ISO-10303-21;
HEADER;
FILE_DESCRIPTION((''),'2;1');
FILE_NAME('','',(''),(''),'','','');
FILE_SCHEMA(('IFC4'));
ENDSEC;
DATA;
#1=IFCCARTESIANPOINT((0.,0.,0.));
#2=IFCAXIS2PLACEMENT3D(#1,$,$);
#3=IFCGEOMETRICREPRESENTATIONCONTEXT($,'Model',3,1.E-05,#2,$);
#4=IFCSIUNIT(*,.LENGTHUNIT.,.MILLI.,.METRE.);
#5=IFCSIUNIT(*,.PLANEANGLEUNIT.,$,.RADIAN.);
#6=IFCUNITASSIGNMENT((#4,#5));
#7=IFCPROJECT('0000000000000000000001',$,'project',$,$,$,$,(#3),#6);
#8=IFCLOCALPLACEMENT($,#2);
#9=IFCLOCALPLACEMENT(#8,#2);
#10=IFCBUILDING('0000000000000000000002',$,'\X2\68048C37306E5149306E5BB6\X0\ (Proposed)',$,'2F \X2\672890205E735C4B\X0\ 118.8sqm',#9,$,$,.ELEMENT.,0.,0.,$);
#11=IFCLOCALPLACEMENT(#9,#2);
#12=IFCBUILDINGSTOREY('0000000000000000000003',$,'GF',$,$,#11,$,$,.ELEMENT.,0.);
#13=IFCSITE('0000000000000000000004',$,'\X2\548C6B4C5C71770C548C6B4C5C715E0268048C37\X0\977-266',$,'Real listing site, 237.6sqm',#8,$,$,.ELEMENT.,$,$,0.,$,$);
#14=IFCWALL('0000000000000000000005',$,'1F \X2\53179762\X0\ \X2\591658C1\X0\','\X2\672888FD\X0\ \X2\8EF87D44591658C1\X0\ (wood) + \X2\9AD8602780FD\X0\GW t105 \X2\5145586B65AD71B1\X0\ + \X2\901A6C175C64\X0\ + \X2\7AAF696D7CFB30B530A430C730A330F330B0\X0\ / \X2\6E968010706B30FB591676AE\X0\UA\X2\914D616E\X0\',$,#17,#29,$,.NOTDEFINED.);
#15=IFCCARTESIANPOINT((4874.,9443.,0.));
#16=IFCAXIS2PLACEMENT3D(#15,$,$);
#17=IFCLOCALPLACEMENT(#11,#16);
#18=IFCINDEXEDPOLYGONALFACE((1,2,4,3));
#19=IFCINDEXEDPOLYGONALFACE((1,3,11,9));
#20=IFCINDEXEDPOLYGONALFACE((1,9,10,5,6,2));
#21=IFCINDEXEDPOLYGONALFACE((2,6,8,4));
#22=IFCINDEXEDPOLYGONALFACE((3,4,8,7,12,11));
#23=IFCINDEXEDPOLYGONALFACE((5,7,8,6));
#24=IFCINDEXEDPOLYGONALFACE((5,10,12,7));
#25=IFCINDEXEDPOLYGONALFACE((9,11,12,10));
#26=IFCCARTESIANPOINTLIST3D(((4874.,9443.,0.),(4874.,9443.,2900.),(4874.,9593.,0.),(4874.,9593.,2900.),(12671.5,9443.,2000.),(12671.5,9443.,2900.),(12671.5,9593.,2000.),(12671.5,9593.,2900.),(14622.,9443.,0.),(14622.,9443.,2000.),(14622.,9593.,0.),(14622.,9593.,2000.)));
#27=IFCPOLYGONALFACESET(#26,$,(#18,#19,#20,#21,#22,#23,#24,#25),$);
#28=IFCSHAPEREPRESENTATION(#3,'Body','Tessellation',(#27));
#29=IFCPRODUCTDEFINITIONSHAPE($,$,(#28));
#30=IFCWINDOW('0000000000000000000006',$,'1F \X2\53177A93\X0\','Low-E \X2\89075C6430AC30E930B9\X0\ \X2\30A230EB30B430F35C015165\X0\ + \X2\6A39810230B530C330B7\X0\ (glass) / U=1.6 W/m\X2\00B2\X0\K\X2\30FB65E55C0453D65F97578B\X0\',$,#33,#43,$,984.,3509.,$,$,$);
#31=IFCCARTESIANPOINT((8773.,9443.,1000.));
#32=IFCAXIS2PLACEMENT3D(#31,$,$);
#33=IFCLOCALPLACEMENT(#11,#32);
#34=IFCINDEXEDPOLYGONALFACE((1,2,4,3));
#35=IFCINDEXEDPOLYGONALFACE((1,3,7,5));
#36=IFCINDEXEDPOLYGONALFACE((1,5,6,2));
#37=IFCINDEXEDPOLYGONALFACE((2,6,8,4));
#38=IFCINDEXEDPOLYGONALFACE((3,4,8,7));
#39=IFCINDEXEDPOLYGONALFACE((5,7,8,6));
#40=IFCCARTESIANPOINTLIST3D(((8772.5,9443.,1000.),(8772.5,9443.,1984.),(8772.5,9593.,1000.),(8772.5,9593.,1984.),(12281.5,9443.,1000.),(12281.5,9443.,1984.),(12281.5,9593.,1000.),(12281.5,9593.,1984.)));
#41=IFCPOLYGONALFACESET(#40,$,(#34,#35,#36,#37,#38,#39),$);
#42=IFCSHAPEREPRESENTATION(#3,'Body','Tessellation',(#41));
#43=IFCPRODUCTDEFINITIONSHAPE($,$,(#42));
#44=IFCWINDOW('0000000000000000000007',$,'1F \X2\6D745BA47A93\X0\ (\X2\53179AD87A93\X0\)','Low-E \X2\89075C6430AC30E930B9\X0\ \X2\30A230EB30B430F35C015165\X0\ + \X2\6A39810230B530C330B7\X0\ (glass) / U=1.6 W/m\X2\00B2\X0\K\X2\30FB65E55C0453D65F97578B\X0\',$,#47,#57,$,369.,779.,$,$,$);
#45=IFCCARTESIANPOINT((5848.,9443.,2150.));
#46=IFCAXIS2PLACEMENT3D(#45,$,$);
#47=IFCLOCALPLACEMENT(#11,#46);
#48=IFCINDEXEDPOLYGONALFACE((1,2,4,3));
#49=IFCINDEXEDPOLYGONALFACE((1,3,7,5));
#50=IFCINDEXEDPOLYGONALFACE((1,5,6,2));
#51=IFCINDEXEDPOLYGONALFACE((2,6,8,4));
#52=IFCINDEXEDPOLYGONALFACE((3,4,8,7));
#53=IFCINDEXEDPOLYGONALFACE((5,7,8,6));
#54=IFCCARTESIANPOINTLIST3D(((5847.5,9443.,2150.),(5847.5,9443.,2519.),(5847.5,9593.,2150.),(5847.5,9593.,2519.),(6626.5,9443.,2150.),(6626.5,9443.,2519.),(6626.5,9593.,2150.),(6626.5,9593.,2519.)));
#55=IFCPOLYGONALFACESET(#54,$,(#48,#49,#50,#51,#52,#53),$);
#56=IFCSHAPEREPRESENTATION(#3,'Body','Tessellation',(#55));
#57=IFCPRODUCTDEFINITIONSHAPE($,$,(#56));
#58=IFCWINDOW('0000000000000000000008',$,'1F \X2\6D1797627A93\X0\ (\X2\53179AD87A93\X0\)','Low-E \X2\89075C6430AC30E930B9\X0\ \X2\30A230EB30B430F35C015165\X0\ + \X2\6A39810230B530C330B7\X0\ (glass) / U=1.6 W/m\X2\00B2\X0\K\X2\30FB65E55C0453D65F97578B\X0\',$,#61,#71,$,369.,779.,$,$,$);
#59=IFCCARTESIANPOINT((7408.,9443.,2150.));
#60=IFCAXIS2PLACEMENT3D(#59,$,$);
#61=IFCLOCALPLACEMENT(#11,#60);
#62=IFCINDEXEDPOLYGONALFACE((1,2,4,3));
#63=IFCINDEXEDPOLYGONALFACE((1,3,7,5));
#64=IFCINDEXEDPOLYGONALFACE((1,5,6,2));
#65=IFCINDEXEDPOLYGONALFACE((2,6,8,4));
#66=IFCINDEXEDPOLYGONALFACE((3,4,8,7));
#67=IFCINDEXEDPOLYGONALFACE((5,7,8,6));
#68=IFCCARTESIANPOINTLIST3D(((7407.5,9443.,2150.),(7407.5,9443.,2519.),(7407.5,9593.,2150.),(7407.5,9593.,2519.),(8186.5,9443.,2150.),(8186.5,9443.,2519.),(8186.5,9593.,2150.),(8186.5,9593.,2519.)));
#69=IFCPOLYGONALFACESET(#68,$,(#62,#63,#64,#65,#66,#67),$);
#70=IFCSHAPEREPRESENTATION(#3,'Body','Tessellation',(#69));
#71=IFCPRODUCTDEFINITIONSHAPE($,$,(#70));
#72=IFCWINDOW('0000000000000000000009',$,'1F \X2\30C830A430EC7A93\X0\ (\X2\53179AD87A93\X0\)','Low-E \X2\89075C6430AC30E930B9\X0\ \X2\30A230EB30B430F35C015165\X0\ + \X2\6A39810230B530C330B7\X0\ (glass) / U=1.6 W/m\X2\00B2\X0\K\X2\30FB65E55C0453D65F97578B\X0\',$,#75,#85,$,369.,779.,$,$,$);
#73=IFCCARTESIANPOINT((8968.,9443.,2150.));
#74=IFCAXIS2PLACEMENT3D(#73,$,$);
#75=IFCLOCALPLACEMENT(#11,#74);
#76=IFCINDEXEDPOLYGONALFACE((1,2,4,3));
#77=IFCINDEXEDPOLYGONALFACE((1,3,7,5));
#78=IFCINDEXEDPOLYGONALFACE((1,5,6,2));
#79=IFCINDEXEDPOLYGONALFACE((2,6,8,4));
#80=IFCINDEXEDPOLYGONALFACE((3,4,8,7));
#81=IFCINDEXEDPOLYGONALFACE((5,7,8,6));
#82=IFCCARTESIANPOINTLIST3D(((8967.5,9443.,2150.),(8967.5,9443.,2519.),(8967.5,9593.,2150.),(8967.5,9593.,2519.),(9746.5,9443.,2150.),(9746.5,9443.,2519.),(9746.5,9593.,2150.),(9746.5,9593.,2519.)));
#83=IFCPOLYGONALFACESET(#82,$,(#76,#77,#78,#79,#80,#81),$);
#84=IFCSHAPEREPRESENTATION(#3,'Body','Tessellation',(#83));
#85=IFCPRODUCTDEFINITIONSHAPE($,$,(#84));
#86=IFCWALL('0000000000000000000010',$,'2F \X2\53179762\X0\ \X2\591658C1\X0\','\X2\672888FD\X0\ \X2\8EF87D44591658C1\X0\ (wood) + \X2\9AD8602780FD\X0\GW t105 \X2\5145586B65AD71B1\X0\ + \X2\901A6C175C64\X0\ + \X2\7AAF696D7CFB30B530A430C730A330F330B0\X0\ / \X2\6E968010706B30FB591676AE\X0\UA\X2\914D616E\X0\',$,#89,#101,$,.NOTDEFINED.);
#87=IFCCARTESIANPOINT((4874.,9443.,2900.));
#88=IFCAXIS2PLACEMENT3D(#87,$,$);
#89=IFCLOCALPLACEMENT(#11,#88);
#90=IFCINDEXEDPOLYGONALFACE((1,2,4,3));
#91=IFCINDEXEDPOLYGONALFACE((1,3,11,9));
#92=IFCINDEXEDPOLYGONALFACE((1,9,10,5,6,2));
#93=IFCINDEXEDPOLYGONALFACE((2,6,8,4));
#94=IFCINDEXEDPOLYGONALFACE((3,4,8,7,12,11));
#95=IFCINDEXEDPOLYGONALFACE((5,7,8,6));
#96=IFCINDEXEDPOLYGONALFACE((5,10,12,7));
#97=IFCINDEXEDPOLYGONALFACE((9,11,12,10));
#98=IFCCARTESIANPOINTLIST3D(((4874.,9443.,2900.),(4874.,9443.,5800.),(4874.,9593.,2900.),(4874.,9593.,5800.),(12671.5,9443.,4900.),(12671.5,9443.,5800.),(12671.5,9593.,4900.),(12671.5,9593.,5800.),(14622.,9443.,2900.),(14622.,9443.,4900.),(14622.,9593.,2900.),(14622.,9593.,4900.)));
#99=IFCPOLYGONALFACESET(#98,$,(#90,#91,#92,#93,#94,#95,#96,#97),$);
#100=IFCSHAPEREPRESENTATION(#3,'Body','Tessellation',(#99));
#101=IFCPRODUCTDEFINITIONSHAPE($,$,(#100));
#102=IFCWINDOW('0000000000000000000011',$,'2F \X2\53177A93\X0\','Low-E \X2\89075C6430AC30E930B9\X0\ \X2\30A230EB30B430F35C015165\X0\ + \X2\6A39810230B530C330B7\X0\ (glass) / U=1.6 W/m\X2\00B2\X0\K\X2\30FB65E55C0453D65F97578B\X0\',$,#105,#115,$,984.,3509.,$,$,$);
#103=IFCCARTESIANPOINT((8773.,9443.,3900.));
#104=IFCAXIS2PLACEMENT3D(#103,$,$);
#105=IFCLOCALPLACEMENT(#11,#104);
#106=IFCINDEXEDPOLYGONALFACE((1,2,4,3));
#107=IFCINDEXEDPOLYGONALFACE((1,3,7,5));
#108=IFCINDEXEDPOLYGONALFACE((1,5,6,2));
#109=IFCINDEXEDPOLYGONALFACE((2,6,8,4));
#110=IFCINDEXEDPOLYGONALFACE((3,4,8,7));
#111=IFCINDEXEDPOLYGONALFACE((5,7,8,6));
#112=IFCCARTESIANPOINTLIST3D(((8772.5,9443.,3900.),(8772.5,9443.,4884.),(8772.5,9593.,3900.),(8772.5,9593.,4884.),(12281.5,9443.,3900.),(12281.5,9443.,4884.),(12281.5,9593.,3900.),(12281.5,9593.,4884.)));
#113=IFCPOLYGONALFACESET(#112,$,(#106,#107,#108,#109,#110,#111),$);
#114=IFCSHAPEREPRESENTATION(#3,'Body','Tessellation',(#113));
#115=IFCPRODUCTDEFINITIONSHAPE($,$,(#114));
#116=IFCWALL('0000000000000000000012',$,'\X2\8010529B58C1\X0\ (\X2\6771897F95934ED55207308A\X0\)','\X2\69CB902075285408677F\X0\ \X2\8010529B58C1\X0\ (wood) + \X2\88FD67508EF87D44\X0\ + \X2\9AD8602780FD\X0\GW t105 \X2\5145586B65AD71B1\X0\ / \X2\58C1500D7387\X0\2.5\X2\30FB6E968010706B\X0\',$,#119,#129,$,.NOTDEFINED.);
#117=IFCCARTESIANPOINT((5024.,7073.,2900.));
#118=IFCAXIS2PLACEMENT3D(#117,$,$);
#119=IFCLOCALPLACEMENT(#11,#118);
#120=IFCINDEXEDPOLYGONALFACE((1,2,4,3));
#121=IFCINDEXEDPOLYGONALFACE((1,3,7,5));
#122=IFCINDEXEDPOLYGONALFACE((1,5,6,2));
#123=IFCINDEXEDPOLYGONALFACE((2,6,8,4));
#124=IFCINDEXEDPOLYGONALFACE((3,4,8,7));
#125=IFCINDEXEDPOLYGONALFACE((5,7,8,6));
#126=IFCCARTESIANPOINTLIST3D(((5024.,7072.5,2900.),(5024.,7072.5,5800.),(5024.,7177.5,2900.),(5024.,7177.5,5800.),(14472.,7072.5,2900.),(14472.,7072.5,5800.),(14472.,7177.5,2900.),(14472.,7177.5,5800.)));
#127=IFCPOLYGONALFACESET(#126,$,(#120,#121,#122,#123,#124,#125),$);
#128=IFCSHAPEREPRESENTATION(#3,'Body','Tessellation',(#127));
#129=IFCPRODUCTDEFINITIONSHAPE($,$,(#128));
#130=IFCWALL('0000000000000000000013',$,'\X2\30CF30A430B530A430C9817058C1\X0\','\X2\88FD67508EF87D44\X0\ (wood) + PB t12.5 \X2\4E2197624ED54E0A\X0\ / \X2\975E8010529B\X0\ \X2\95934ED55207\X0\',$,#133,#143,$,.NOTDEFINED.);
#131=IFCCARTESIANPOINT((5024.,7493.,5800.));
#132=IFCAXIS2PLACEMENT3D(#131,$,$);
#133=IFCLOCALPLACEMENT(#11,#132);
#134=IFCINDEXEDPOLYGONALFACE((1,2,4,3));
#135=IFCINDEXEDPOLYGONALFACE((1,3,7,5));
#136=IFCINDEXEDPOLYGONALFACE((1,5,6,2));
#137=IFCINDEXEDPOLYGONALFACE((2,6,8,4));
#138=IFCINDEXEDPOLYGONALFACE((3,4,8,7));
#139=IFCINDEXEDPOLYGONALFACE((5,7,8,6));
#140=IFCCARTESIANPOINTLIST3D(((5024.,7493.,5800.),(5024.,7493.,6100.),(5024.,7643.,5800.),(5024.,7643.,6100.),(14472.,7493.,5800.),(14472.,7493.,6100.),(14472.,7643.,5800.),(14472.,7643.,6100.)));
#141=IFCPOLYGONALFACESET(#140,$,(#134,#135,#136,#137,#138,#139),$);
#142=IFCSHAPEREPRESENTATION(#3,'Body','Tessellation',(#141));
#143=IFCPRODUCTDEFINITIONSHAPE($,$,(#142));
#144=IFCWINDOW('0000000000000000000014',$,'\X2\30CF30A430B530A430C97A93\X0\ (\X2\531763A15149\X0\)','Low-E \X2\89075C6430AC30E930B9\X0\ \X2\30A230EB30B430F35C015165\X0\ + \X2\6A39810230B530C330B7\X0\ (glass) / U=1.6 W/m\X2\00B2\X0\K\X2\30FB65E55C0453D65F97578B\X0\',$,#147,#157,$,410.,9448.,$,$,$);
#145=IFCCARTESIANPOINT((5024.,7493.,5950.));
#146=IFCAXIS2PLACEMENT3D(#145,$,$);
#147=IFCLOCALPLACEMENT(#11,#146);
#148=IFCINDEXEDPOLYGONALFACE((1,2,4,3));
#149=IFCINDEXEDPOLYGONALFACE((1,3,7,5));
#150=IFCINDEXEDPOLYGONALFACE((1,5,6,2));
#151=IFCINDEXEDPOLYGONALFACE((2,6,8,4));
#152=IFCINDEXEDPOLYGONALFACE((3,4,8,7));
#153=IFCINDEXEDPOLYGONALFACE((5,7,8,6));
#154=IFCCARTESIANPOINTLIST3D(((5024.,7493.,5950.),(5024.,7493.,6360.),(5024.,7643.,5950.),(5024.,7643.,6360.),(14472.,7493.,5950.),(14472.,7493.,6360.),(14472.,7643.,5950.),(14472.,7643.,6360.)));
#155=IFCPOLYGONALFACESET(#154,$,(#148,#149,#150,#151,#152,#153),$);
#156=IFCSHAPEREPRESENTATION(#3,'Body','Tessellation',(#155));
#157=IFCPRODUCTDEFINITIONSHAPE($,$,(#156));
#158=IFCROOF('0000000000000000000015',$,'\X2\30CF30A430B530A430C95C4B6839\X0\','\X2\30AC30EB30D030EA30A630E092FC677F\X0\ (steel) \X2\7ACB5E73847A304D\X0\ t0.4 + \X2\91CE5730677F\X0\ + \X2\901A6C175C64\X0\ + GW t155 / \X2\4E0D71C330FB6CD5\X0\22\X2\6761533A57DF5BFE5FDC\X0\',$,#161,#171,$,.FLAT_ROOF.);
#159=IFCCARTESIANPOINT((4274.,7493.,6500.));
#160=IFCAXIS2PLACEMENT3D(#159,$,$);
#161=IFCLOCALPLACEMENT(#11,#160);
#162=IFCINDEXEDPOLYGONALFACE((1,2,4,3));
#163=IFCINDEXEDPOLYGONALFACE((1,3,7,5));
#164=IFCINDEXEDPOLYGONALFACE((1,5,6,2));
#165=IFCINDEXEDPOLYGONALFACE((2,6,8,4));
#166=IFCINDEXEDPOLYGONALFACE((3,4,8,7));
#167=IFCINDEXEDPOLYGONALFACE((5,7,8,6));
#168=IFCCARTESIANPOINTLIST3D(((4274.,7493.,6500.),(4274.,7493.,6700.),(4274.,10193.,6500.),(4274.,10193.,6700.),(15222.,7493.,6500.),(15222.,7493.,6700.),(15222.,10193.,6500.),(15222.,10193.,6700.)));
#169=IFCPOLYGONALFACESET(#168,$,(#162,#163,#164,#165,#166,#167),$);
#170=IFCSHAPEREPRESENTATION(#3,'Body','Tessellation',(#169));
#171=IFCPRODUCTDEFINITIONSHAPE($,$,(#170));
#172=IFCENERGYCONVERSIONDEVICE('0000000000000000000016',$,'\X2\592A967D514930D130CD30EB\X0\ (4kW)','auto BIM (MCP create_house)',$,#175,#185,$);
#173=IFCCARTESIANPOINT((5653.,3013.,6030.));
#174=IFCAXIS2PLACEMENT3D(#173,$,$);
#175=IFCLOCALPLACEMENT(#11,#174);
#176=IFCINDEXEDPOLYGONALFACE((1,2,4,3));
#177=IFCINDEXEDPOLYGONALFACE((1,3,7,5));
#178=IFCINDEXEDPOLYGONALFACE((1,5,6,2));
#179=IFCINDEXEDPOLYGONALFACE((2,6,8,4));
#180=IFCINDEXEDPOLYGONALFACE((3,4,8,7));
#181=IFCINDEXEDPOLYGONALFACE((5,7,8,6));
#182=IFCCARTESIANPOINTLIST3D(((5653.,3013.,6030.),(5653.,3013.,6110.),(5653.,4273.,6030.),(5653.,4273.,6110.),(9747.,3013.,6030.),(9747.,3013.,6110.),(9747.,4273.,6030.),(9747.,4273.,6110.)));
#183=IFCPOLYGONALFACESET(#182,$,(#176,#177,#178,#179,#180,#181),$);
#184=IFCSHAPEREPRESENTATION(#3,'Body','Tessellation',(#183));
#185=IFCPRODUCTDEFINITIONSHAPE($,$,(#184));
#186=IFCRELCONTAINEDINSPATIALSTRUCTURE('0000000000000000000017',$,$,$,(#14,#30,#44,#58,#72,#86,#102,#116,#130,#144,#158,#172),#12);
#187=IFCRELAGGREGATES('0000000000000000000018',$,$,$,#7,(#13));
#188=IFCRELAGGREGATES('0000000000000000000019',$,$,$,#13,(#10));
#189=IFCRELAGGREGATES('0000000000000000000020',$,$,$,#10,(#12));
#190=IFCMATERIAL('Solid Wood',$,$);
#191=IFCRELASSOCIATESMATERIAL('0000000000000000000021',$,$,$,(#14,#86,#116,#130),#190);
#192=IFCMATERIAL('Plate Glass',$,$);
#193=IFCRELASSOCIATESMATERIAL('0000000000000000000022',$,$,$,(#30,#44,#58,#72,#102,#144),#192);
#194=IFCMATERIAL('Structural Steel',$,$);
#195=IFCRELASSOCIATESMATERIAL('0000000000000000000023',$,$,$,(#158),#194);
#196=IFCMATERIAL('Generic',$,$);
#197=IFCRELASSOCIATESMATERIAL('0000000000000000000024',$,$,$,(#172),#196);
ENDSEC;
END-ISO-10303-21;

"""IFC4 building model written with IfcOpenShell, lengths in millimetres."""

from ifc_helpers import new_model, si_unit, frame, frame_2d, origin, place, context, project, spatial, rectangle, extrude, material, element, fill, save


model = new_model("IFC4")

# Units and contexts
model_context = context("Model", 3, precision=1e-05, world=origin())
ifc_project = project(units=[si_unit("LENGTHUNIT", "METRE", prefix="MILLI"), si_unit("PLANEANGLEUNIT", "RADIAN")], contexts=[model_context])

# Site, building, storey
site_placement = place(None, origin())
site = spatial("IfcSite", under=ifc_project, at=site_placement, Name="和歌山県和歌山市栄谷977-266", ObjectType="Real listing site, 237.6sqm", CompositionType="ELEMENT", RefElevation=0.0)
building_placement = place(site_placement, origin())
building = spatial("IfcBuilding", under=site, at=building_placement, Name="栄谷の光の家 (Proposed)", ObjectType="2F 木造平屋 118.8sqm", CompositionType="ELEMENT", ElevationOfRefHeight=0.0, ElevationOfTerrain=0.0)
storey_placement = place(building_placement, origin())
storey = spatial("IfcBuildingStorey", under=building, at=storey_placement, Name="GF", CompositionType="ELEMENT", Elevation=0.0)

# Wall, openings, windows
ifc_material_1 = material(Name="Solid Wood")
wall_1_placement = place(storey_placement, frame((4874.0, 9443.0, 0.0)))
wall_1 = element("IfcWall", 1, at=wall_1_placement, inside=storey, material=ifc_material_1, Name="1F 北面 外壁", Description="木製 軸組外壁 (wood) + 高性能GW t105 充填断熱 + 通気層 + 窯業系サイディング / 準耐火・外皮UA配慮", PredefinedType="NOTDEFINED", context=model_context, shape_type="SweptSolid", body=[
    extrude(rectangle(XDim=9748.0, YDim=150.0, at=frame_2d((4874.0, 75.0))), frame((4874.0, 9443.0, 0.0)), (0.0, 0.0, 1.0), 2900.0),
])
opening_1_placement = place(storey_placement, frame((8773.0, 9443.0, 1000.0)))
opening_1 = element("IfcOpeningElement", 2, at=opening_1_placement, cuts=wall_1, PredefinedType="NOTDEFINED", context=model_context, shape_type="SweptSolid", body=[
    extrude(rectangle(XDim=3509.0, YDim=150.0, at=frame_2d((1754.0, 75.0))), frame((8773.0, 9443.0, 1000.0)), (0.0, 0.0, 1.0), 984.0),
])
opening_2_placement = place(storey_placement, frame((5848.0, 9443.0, 2150.0)))
opening_2 = element("IfcOpeningElement", 3, at=opening_2_placement, cuts=wall_1, PredefinedType="NOTDEFINED", context=model_context, shape_type="SweptSolid", body=[
    extrude(rectangle(XDim=779.0, YDim=150.0, at=frame_2d((389.0, 75.0))), frame((5848.0, 9443.0, 2150.0)), (0.0, 0.0, 1.0), 369.0),
])
opening_3_placement = place(storey_placement, frame((7408.0, 9443.0, 2150.0)))
opening_3 = element("IfcOpeningElement", 4, at=opening_3_placement, cuts=wall_1, PredefinedType="NOTDEFINED", context=model_context, shape_type="SweptSolid", body=[
    extrude(rectangle(XDim=779.0, YDim=150.0, at=frame_2d((389.0, 75.0))), frame((7408.0, 9443.0, 2150.0)), (0.0, 0.0, 1.0), 369.0),
])
opening_4_placement = place(storey_placement, frame((8968.0, 9443.0, 2150.0)))
opening_4 = element("IfcOpeningElement", 5, at=opening_4_placement, cuts=wall_1, PredefinedType="NOTDEFINED", context=model_context, shape_type="SweptSolid", body=[
    extrude(rectangle(XDim=779.0, YDim=150.0, at=frame_2d((389.0, 75.0))), frame((8968.0, 9443.0, 2150.0)), (0.0, 0.0, 1.0), 369.0),
])
ifc_material_2 = material(Name="Plate Glass")
window_1_placement = place(storey_placement, frame((8773.0, 9443.0, 1000.0)))
window_1 = element("IfcWindow", 6, at=window_1_placement, inside=storey, material=ifc_material_2, Name="1F 北窓", Description="Low-E 複層ガラス アルゴン封入 + 樹脂サッシ (glass) / U=1.6 W/m²K・日射取得型", OverallHeight=984.0, OverallWidth=3509.0, context=model_context, shape_type="SweptSolid", body=[
    extrude(rectangle(XDim=3509.0, YDim=150.0, at=frame_2d((1754.0, 75.0))), frame((8773.0, 9443.0, 1000.0)), (0.0, 0.0, 1.0), 984.0),
])
fill(opening_1, window_1)
window_2_placement = place(storey_placement, frame((5848.0, 9443.0, 2150.0)))
window_2 = element("IfcWindow", 7, at=window_2_placement, inside=storey, material=ifc_material_2, Name="1F 浴室窓 (北高窓)", Description="Low-E 複層ガラス アルゴン封入 + 樹脂サッシ (glass) / U=1.6 W/m²K・日射取得型", OverallHeight=369.0, OverallWidth=779.0, context=model_context, shape_type="SweptSolid", body=[
    extrude(rectangle(XDim=779.0, YDim=150.0, at=frame_2d((389.0, 75.0))), frame((5848.0, 9443.0, 2150.0)), (0.0, 0.0, 1.0), 369.0),
])
fill(opening_2, window_2)
window_3_placement = place(storey_placement, frame((7408.0, 9443.0, 2150.0)))
window_3 = element("IfcWindow", 8, at=window_3_placement, inside=storey, material=ifc_material_2, Name="1F 洗面窓 (北高窓)", Description="Low-E 複層ガラス アルゴン封入 + 樹脂サッシ (glass) / U=1.6 W/m²K・日射取得型", OverallHeight=369.0, OverallWidth=779.0, context=model_context, shape_type="SweptSolid", body=[
    extrude(rectangle(XDim=779.0, YDim=150.0, at=frame_2d((389.0, 75.0))), frame((7408.0, 9443.0, 2150.0)), (0.0, 0.0, 1.0), 369.0),
])
fill(opening_3, window_3)
window_4_placement = place(storey_placement, frame((8968.0, 9443.0, 2150.0)))
window_4 = element("IfcWindow", 9, at=window_4_placement, inside=storey, material=ifc_material_2, Name="1F トイレ窓 (北高窓)", Description="Low-E 複層ガラス アルゴン封入 + 樹脂サッシ (glass) / U=1.6 W/m²K・日射取得型", OverallHeight=369.0, OverallWidth=779.0, context=model_context, shape_type="SweptSolid", body=[
    extrude(rectangle(XDim=779.0, YDim=150.0, at=frame_2d((389.0, 75.0))), frame((8968.0, 9443.0, 2150.0)), (0.0, 0.0, 1.0), 369.0),
])
fill(opening_4, window_4)

# Wall, opening, window
wall_2_placement = place(storey_placement, frame((4874.0, 9443.0, 2900.0)))
wall_2 = element("IfcWall", 10, at=wall_2_placement, inside=storey, material=ifc_material_1, Name="2F 北面 外壁", Description="木製 軸組外壁 (wood) + 高性能GW t105 充填断熱 + 通気層 + 窯業系サイディング / 準耐火・外皮UA配慮", PredefinedType="NOTDEFINED", context=model_context, shape_type="SweptSolid", body=[
    extrude(rectangle(XDim=9748.0, YDim=150.0, at=frame_2d((4874.0, 75.0))), frame((4874.0, 9443.0, 2900.0)), (0.0, 0.0, 1.0), 2900.0),
])
opening_5_placement = place(storey_placement, frame((8773.0, 9443.0, 3900.0)))
opening_5 = element("IfcOpeningElement", 11, at=opening_5_placement, cuts=wall_2, PredefinedType="NOTDEFINED", context=model_context, shape_type="SweptSolid", body=[
    extrude(rectangle(XDim=3509.0, YDim=150.0, at=frame_2d((1754.0, 75.0))), frame((8773.0, 9443.0, 3900.0)), (0.0, 0.0, 1.0), 984.0),
])
window_5_placement = place(storey_placement, frame((8773.0, 9443.0, 3900.0)))
window_5 = element("IfcWindow", 12, at=window_5_placement, inside=storey, material=ifc_material_2, Name="2F 北窓", Description="Low-E 複層ガラス アルゴン封入 + 樹脂サッシ (glass) / U=1.6 W/m²K・日射取得型", OverallHeight=984.0, OverallWidth=3509.0, context=model_context, shape_type="SweptSolid", body=[
    extrude(rectangle(XDim=3509.0, YDim=150.0, at=frame_2d((1754.0, 75.0))), frame((8773.0, 9443.0, 3900.0)), (0.0, 0.0, 1.0), 984.0),
])
fill(opening_5, window_5)

# Wall
wall_3_placement = place(storey_placement, frame((5024.0, 7073.0, 2900.0)))
element("IfcWall", 13, at=wall_3_placement, inside=storey, material=ifc_material_1, Name="耐力壁 (東西間仕切り)", Description="構造用合板 耐力壁 (wood) + 製材軸組 + 高性能GW t105 充填断熱 / 壁倍率2.5・準耐火", PredefinedType="NOTDEFINED", context=model_context, shape_type="SweptSolid", body=[
    extrude(rectangle(XDim=9448.0, YDim=105.0, at=frame_2d((4724.0, 52.0))), frame((5024.0, 7073.0, 2900.0)), (0.0, 0.0, 1.0), 2900.0),
])

# Wall, opening, window
wall_4_placement = place(storey_placement, frame((5024.0, 7493.0, 5800.0)))
wall_4 = element("IfcWall", 14, at=wall_4_placement, inside=storey, material=ifc_material_1, Name="ハイサイド腰壁", Description="製材軸組 (wood) + PB t12.5 両面仕上 / 非耐力 間仕切", PredefinedType="NOTDEFINED", context=model_context, shape_type="SweptSolid", body=[
    extrude(rectangle(XDim=9448.0, YDim=150.0, at=frame_2d((4724.0, 75.0))), frame((5024.0, 7493.0, 5800.0)), (0.0, 0.0, 1.0), 700.0),
])
opening_6_placement = place(storey_placement, frame((5024.0, 7493.0, 5950.0)))
opening_6 = element("IfcOpeningElement", 15, at=opening_6_placement, cuts=wall_4, PredefinedType="NOTDEFINED", context=model_context, shape_type="SweptSolid", body=[
    extrude(rectangle(XDim=9448.0, YDim=150.0, at=frame_2d((4724.0, 75.0))), frame((5024.0, 7493.0, 5950.0)), (0.0, 0.0, 1.0), 410.0),
])
window_6_placement = place(storey_placement, frame((5024.0, 7493.0, 5950.0)))
window_6 = element("IfcWindow", 16, at=window_6_placement, inside=storey, material=ifc_material_2, Name="ハイサイド窓 (北採光)", Description="Low-E 複層ガラス アルゴン封入 + 樹脂サッシ (glass) / U=1.6 W/m²K・日射取得型", OverallHeight=410.0, OverallWidth=9448.0, context=model_context, shape_type="SweptSolid", body=[
    extrude(rectangle(XDim=9448.0, YDim=150.0, at=frame_2d((4724.0, 75.0))), frame((5024.0, 7493.0, 5950.0)), (0.0, 0.0, 1.0), 410.0),
])
fill(opening_6, window_6)

# Roof
ifc_material_3 = material(Name="Structural Steel")
roof_placement = place(storey_placement, frame((4274.0, 7493.0, 6500.0)))
element("IfcRoof", 17, at=roof_placement, inside=storey, material=ifc_material_3, Name="ハイサイド屋根", Description="ガルバリウム鋼板 (steel) 立平葺き t0.4 + 野地板 + 通気層 + GW t155 / 不燃・法22条区域対応", PredefinedType="FLAT_ROOF", context=model_context, shape_type="SweptSolid", body=[
    extrude(rectangle(XDim=10948.0, YDim=2700.0, at=frame_2d((5474.0, 1350.0))), frame((4274.0, 7493.0, 6500.0)), (0.0, 0.0, 1.0), 200.0),
])

# Energy conversion device
ifc_material_4 = material(Name="Generic")
energy_conversion_device_placement = place(storey_placement, frame((5653.0, 3013.0, 6030.0)))
element("IfcEnergyConversionDevice", 18, at=energy_conversion_device_placement, inside=storey, material=ifc_material_4, Name="太陽光パネル (4kW)", Description="auto BIM (MCP create_house)", context=model_context, shape_type="SweptSolid", body=[
    extrude(rectangle(XDim=4094.0, YDim=1260.0, at=frame_2d((2047.0, 630.0))), frame((5653.0, 3013.0, 6030.0)), (0.0, 0.0, 1.0), 80.0),
])

save(model, "model.ifc")
